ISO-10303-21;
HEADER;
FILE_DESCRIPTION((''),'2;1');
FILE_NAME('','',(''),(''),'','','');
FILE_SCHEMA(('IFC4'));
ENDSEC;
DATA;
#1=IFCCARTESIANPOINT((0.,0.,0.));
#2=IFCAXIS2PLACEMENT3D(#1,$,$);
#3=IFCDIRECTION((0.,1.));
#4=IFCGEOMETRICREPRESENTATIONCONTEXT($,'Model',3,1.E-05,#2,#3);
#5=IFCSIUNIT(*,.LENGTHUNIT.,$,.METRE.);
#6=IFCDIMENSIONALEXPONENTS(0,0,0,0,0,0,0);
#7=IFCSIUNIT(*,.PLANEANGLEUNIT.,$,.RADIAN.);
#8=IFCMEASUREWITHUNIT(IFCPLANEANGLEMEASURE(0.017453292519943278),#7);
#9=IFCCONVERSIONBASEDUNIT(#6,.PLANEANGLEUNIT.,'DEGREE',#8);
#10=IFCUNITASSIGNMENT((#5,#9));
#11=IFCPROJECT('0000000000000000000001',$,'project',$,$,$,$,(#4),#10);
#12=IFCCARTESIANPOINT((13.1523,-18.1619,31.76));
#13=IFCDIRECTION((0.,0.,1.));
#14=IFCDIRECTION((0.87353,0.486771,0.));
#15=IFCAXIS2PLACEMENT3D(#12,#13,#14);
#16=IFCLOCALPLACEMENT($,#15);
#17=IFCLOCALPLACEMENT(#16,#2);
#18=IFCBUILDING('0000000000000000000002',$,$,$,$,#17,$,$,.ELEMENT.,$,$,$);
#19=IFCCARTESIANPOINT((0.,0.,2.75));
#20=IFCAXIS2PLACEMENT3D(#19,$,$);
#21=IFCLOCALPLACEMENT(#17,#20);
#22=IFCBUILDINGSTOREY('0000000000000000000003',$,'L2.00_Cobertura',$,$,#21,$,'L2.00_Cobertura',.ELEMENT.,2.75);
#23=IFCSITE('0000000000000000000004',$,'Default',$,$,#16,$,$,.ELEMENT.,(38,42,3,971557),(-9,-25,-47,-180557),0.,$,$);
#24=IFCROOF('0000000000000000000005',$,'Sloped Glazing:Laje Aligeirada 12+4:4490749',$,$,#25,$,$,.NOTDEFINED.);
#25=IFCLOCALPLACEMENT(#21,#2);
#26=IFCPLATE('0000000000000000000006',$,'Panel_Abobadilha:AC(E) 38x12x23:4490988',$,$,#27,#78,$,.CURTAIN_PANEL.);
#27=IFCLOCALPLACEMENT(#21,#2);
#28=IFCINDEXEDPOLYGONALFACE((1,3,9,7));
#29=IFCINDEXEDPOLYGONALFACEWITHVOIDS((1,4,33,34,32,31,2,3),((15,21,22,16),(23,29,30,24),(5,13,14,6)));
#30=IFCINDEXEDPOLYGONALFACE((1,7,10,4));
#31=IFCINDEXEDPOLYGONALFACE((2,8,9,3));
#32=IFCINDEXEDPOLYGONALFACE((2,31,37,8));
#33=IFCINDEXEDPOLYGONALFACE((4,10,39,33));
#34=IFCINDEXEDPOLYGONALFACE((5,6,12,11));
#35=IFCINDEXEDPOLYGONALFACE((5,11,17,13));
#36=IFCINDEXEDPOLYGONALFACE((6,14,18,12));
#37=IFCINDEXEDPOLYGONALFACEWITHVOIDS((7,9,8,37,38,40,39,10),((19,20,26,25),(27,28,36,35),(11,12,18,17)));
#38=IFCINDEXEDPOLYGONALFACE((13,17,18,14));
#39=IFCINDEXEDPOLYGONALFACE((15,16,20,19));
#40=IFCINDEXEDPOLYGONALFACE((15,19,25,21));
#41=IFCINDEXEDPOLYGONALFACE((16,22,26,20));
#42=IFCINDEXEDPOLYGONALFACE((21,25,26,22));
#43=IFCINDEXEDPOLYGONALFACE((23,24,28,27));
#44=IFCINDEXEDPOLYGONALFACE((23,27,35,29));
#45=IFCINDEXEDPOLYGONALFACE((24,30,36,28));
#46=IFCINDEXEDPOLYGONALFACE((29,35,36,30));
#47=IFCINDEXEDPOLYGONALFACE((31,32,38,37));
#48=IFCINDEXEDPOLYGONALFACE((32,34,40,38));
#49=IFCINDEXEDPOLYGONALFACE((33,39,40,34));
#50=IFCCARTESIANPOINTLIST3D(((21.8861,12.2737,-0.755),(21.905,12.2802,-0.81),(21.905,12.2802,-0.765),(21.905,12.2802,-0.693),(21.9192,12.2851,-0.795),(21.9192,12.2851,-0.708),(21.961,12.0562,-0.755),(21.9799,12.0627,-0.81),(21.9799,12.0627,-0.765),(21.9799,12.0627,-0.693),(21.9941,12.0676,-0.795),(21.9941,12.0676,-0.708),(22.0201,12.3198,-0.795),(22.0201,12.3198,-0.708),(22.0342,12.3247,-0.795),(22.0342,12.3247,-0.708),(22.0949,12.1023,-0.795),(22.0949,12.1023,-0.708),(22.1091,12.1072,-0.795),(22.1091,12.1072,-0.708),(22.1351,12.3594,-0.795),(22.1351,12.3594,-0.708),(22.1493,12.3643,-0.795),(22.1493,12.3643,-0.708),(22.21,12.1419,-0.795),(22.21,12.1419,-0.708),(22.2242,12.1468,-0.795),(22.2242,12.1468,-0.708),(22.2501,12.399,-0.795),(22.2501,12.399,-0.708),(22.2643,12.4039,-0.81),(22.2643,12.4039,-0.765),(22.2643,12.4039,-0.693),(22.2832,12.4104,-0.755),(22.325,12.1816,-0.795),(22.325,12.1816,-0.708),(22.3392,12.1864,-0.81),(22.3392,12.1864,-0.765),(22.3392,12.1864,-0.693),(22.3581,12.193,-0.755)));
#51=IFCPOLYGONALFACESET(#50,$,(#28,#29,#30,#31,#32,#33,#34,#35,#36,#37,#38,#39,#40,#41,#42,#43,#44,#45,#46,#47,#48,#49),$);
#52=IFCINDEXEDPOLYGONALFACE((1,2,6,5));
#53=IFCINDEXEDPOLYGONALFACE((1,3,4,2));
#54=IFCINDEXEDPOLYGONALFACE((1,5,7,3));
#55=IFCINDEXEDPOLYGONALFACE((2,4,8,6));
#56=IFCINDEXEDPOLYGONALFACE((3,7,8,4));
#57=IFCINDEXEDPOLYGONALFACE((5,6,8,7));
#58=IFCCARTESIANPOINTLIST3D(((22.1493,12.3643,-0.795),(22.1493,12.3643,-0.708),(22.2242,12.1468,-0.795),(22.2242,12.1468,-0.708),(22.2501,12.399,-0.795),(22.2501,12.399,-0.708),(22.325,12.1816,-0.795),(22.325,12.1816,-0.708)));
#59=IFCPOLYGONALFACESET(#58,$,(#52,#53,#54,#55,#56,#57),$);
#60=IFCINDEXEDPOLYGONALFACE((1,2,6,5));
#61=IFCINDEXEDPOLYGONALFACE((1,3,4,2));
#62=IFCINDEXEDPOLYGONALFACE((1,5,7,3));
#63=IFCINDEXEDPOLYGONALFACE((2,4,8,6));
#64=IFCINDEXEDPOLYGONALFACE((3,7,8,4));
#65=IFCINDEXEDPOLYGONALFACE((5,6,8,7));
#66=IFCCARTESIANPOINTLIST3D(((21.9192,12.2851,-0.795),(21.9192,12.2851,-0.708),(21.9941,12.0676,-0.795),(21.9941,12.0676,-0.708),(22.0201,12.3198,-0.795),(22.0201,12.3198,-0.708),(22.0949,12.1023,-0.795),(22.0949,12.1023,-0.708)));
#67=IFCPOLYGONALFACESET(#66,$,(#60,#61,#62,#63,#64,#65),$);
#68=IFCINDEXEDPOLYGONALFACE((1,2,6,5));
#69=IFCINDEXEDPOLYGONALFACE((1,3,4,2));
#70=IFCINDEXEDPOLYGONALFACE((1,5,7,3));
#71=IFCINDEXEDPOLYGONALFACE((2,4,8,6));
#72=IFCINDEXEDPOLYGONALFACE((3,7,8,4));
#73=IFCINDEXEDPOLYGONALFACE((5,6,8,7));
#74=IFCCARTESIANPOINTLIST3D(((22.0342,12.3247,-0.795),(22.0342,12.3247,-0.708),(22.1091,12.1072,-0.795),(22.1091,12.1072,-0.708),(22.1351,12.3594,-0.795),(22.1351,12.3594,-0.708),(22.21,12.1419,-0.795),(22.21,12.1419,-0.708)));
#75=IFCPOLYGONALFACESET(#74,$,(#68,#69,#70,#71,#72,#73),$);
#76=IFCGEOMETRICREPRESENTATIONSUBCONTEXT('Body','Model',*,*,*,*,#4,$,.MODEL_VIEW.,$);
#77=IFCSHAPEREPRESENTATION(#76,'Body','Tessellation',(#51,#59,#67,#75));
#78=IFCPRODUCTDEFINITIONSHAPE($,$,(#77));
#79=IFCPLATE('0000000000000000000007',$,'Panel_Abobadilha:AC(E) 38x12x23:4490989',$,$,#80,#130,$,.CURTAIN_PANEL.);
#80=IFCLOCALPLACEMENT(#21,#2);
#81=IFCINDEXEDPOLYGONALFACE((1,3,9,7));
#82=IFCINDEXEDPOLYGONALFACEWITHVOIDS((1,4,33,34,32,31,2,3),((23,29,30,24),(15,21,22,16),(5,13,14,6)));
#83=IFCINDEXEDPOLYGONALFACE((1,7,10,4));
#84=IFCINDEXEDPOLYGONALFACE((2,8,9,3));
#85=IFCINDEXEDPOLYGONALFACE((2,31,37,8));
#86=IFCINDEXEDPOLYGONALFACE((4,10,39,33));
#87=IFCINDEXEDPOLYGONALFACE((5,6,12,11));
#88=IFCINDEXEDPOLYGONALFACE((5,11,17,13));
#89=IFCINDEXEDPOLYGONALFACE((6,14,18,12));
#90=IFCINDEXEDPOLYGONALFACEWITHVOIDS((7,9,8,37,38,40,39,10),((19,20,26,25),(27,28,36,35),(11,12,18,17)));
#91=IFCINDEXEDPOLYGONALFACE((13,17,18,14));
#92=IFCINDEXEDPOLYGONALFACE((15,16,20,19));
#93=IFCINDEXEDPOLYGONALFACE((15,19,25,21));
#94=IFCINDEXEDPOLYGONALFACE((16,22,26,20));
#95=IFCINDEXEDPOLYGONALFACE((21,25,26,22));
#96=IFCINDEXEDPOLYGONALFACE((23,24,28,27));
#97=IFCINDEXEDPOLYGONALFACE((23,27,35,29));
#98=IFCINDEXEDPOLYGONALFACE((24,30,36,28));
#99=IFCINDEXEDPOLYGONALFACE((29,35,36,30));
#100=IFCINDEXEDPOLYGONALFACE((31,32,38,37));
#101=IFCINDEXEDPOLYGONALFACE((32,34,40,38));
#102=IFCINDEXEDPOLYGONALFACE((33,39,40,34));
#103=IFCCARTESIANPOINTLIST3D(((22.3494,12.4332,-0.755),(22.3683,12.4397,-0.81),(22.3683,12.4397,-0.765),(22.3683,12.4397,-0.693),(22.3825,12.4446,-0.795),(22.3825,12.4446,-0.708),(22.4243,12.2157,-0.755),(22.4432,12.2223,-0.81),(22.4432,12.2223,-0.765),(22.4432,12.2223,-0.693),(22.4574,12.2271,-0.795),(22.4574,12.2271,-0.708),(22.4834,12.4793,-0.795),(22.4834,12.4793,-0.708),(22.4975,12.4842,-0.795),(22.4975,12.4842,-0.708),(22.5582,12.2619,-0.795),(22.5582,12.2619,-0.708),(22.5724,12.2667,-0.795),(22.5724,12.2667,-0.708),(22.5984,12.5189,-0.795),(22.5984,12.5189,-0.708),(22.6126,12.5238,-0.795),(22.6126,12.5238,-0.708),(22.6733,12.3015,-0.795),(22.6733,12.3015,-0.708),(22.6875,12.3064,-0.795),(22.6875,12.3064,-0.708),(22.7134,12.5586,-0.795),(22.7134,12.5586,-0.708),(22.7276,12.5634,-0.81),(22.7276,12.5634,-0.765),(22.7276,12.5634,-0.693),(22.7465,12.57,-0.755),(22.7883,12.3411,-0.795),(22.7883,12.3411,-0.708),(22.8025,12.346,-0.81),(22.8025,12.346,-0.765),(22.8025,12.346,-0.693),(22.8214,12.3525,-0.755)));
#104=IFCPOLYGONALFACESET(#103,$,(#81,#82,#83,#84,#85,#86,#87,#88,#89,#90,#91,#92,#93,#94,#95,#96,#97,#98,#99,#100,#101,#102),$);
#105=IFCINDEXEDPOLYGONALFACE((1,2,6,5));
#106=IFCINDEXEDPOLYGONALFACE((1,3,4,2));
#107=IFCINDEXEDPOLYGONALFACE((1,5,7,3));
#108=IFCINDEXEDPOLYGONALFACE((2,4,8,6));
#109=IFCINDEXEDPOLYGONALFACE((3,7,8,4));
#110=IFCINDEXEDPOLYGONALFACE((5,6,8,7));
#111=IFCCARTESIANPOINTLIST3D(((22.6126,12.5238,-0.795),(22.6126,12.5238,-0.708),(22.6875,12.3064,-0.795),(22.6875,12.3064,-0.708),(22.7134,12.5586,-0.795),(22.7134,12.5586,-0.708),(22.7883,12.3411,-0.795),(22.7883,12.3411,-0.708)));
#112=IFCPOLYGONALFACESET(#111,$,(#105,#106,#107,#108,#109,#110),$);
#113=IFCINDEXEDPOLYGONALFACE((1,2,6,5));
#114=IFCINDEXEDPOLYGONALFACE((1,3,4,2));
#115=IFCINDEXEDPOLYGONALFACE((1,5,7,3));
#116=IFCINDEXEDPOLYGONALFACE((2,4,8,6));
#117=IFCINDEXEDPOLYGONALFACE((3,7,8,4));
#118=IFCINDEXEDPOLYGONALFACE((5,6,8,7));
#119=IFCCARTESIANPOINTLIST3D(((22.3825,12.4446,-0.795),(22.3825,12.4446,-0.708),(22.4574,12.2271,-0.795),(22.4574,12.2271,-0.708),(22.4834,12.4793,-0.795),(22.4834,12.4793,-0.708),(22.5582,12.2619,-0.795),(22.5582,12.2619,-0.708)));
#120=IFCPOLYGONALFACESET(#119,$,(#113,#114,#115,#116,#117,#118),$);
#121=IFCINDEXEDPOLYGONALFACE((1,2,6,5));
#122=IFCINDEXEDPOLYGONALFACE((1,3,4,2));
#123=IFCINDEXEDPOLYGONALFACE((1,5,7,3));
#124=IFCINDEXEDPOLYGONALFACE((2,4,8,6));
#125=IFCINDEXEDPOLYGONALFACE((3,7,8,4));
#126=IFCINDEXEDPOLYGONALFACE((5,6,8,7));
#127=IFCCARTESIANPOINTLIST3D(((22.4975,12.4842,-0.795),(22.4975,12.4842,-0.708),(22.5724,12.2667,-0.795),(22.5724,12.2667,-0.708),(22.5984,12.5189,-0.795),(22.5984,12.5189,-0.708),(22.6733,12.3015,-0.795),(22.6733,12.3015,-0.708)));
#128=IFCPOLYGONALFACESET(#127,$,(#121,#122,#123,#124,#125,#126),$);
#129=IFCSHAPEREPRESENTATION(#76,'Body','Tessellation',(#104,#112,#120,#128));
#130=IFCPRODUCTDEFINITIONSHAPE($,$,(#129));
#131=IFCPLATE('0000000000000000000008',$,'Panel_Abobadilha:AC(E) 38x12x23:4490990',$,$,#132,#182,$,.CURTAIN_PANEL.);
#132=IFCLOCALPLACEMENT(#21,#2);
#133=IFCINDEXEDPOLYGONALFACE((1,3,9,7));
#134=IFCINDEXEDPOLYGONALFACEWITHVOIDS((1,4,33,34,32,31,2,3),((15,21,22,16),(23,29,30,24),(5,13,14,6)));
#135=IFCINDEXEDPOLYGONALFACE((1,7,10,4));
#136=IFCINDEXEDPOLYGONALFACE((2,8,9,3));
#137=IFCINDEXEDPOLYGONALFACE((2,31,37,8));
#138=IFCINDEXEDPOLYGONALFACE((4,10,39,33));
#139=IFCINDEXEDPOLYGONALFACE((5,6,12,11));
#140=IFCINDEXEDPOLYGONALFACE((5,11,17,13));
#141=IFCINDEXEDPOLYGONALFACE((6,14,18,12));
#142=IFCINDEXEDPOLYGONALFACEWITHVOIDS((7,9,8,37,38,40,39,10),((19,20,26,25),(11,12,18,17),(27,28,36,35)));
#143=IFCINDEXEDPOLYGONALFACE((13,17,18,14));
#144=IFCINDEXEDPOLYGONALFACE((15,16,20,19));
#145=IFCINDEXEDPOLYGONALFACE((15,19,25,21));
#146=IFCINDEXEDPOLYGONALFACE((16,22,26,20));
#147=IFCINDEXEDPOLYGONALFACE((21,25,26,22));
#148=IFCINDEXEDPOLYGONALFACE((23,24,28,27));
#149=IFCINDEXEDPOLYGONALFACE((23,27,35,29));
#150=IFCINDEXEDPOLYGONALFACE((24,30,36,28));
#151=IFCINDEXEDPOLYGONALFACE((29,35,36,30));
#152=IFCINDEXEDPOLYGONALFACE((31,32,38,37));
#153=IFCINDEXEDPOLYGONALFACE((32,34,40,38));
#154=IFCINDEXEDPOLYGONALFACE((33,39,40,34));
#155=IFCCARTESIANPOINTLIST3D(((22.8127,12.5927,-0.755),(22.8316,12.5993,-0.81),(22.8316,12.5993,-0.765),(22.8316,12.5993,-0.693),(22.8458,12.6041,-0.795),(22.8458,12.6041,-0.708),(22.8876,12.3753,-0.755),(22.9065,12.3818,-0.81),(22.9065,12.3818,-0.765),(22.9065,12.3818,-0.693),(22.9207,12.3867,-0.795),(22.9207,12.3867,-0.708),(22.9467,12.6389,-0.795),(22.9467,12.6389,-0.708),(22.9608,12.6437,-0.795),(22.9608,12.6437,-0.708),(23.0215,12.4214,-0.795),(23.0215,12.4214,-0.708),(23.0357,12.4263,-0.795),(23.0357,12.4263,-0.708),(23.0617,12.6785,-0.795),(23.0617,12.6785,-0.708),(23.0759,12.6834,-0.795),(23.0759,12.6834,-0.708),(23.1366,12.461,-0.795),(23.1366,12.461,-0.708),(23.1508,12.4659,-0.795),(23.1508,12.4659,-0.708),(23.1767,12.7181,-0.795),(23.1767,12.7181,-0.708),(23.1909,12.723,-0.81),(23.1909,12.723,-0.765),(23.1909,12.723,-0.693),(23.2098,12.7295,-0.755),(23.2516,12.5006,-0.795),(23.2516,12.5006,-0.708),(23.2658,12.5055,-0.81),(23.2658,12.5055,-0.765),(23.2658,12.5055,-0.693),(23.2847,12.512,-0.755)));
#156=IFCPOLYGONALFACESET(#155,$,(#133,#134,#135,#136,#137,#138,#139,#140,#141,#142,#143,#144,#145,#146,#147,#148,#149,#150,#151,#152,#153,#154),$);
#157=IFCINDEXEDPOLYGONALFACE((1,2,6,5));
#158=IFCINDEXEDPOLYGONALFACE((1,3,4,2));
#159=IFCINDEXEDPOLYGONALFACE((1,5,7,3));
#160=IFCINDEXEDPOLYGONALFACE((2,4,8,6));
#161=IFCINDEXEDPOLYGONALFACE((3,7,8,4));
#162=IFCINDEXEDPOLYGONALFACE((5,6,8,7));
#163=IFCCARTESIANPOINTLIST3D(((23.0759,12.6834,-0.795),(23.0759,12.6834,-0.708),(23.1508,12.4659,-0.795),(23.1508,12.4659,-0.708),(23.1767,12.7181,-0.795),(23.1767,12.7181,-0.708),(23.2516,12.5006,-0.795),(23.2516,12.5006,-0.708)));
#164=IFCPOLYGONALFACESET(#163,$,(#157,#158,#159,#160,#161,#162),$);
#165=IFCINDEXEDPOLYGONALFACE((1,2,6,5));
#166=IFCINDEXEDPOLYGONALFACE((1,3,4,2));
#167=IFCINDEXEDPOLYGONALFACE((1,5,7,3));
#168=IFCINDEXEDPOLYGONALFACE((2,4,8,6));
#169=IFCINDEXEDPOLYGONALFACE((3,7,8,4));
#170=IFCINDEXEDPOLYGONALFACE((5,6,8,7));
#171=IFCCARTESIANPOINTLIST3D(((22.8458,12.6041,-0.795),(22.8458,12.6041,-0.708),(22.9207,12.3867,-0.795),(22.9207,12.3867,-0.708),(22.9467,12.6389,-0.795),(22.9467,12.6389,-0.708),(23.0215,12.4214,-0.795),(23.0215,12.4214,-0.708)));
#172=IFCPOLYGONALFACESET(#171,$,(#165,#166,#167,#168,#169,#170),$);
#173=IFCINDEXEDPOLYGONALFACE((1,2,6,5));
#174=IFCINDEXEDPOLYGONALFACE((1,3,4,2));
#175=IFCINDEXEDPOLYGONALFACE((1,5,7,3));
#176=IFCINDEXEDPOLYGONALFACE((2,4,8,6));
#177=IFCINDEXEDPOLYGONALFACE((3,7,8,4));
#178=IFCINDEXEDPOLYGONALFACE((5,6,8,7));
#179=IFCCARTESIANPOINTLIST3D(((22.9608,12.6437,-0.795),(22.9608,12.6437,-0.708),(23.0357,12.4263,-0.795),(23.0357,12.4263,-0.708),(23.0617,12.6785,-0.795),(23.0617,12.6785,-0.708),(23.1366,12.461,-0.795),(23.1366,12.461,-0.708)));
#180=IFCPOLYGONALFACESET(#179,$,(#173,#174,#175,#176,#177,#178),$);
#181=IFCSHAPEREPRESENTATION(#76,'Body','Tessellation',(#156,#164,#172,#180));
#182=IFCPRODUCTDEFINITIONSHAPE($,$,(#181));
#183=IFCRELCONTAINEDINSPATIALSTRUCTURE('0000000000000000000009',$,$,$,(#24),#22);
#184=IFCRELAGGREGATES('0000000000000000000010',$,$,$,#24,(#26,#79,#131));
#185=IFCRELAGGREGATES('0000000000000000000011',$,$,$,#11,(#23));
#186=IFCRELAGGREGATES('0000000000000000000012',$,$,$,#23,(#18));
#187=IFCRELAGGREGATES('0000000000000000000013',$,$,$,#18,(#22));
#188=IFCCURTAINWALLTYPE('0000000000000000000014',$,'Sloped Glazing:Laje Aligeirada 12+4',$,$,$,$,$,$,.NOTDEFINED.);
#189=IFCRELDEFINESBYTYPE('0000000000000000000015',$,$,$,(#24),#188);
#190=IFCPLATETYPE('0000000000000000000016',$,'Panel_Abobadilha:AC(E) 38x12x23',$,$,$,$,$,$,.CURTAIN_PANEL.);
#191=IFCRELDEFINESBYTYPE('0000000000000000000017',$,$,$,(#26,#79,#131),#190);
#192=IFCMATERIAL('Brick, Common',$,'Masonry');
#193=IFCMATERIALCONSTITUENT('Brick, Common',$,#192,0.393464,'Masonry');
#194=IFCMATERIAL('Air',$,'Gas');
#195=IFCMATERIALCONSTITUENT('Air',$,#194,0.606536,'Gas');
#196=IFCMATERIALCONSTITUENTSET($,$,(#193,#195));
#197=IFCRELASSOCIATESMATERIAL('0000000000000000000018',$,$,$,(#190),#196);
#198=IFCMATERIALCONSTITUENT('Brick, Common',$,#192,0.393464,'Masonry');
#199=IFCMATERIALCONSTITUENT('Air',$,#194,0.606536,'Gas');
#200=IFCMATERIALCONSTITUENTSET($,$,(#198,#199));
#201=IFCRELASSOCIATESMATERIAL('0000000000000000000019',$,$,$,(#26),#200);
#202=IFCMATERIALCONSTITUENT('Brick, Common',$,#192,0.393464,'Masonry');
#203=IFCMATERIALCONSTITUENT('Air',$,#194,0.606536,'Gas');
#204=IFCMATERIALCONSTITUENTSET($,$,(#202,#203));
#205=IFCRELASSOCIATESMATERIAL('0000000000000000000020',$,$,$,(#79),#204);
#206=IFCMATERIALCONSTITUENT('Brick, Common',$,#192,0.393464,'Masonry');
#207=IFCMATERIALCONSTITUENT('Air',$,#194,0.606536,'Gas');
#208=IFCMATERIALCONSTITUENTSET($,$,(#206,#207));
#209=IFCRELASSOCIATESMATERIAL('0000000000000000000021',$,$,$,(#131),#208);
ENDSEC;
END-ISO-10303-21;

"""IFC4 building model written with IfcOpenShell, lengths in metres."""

from ifc_helpers import new_model, entity, si_unit, converted_unit, direction, frame, origin, place, context, subcontext, project, spatial, indexed_curve, outline, extrude, source, transform, mapped, material, constituent, constituent_set, type_object, type_shapes, element, aggregate, save


model = new_model("IFC4")

# Units and contexts
model_context = context("Model", 3, precision=1e-05, world=origin(), true_north=direction((0.0, 1.0)))
body_context = subcontext(model_context, "Body", "Model", "MODEL_VIEW")
ifc_project = project(units=[si_unit("LENGTHUNIT", "METRE"), converted_unit("PLANEANGLEUNIT", "DEGREE", entity("IfcPlaneAngleMeasure", 0.017453292519943278), si_unit("PLANEANGLEUNIT", "RADIAN"), dimensions=[0, 0, 0, 0, 0, 0, 0])], contexts=[model_context])

# Site, building, storey
site_placement = place(None, frame((13.1523, -18.1619, 31.76), z_axis=(0.0, 0.0, 1.0), x_axis=(0.87353, 0.486771, 0.0)))
site = spatial("IfcSite", under=ifc_project, at=site_placement, Name="Default", CompositionType="ELEMENT", RefLatitude=(38, 42, 3, 971557), RefLongitude=(-9, -25, -47, -180557), RefElevation=0.0)
building_placement = place(site_placement, origin())
building = spatial("IfcBuilding", under=site, at=building_placement, CompositionType="ELEMENT")
storey_placement = place(building_placement, frame((0.0, 0.0, 2.75)))
storey = spatial("IfcBuildingStorey", under=building, at=storey_placement, Name="L2.00_Cobertura", LongName="L2.00_Cobertura", CompositionType="ELEMENT", Elevation=2.75)

# Roof, plates
curtain_wall_type = type_object("IfcCurtainWallType", Name="Sloped Glazing:Laje Aligeirada 12+4", PredefinedType="NOTDEFINED")
roof_placement = place(storey_placement, frame((0.0, 0.0, -2.75)))
roof = element("IfcRoof", 1, at=roof_placement, inside=storey, type_object=curtain_wall_type, Name="Sloped Glazing:Laje Aligeirada 12+4:4490749", PredefinedType="NOTDEFINED")
ifc_material_1 = material(Name="Brick, Common", Category="Masonry")
ifc_material_2 = material(Name="Air", Category="Gas")
ifc_constituent_1 = constituent(ifc_material_1, Name="Brick, Common", Category="Masonry", fraction=0.393464)
ifc_constituent_2 = constituent(ifc_material_2, Name="Air", Category="Gas", fraction=0.606536)
ifc_constituent_set_1 = constituent_set(constituents=[ifc_constituent_1, ifc_constituent_2])
plate_type = type_object("IfcPlateType", Name="Panel_Abobadilha:AC(E) 38x12x23", PredefinedType="CURTAIN_PANEL", material=ifc_constituent_set_1)
shared_shape_1 = source(origin(), body_context, "Body", "SweptSolid", [
    extrude(outline(indexed_curve([(-0.19, -0.0543), (0.19, -0.0543), (0.19, -0.0093), (0.21, 0.0007), (0.19, 0.0628), (-0.19, 0.0628), (-0.21, 0.0007), (-0.19, -0.0093), (-0.19, -0.0543)], self_intersect=False), holes=[indexed_curve([(-0.0683, 0.0477), (-0.0683, -0.0393), (-0.175, -0.0393), (-0.175, 0.0477), (-0.0683, 0.0477)], self_intersect=False), indexed_curve([(0.0533, 0.0477), (0.0533, -0.0393), (-0.0533, -0.0393), (-0.0533, 0.0477), (0.0533, 0.0477)], self_intersect=False), indexed_curve([(0.175, 0.0477), (0.175, -0.0393), (0.0683, -0.0393), (0.0683, 0.0477), (0.175, 0.0477)], self_intersect=False)]), frame((0.0, 0.0543, 0.0)), (0.0, 0.0, 1.0), 0.23),
    extrude(outline(indexed_curve([(-0.0533, -0.0435), (0.0533, -0.0435), (0.0533, 0.0435), (-0.0533, 0.0435), (-0.0533, -0.0435)], self_intersect=False)), frame((0.1217, 0.0585, 0.0), z_axis=(0.0, 0.0, 1.0), x_axis=(-1.0, 0.0, 0.0)), (0.0, 0.0, 1.0), 0.23),
    extrude(outline(indexed_curve([(-0.0533, -0.0435), (0.0533, -0.0435), (0.0533, 0.0435), (-0.0533, 0.0435), (-0.0533, -0.0435)], self_intersect=False)), frame((-0.1217, 0.0585, 0.0), z_axis=(0.0, 0.0, 1.0), x_axis=(-1.0, 0.0, 0.0)), (0.0, 0.0, 1.0), 0.23),
    extrude(outline(indexed_curve([(-0.0533, -0.0435), (0.0533, -0.0435), (0.0533, 0.0435), (-0.0533, 0.0435), (-0.0533, -0.0435)], self_intersect=False)), frame((0.0, 0.0585, 0.0), z_axis=(0.0, 0.0, 1.0), x_axis=(-1.0, 0.0, 0.0)), (0.0, 0.0, 1.0), 0.23),
])
type_shapes(plate_type, [shared_shape_1])
ifc_constituent_3 = constituent(ifc_material_1, Name="Brick, Common", Category="Masonry", fraction=0.393464)
ifc_constituent_4 = constituent(ifc_material_2, Name="Air", Category="Gas", fraction=0.606536)
ifc_constituent_set_2 = constituent_set(constituents=[ifc_constituent_3, ifc_constituent_4])
plate_1_placement = place(roof_placement, frame((22.0847, 12.3421, 1.94), z_axis=(0.325568, -0.945519, 0.0), x_axis=(0.945519, 0.325568, 0.0)))
plate_1 = element("IfcPlate", 2, at=plate_1_placement, type_object=plate_type, material=ifc_constituent_set_2, Name="Panel_Abobadilha:AC(E) 38x12x23:4490988", PredefinedType="CURTAIN_PANEL", context=body_context, shape_type="MappedRepresentation", body=[
    mapped(shared_shape_1, transform((0.0, 0.0, 0.0), scale=1.0)),
])
ifc_constituent_5 = constituent(ifc_material_1, Name="Brick, Common", Category="Masonry", fraction=0.393464)
ifc_constituent_6 = constituent(ifc_material_2, Name="Air", Category="Gas", fraction=0.606536)
ifc_constituent_set_3 = constituent_set(constituents=[ifc_constituent_5, ifc_constituent_6])
plate_2_placement = place(roof_placement, frame((22.548, 12.5016, 1.94), z_axis=(0.325568, -0.945519, 0.0), x_axis=(0.945519, 0.325568, 0.0)))
plate_2 = element("IfcPlate", 3, at=plate_2_placement, type_object=plate_type, material=ifc_constituent_set_3, Name="Panel_Abobadilha:AC(E) 38x12x23:4490989", PredefinedType="CURTAIN_PANEL", context=body_context, shape_type="MappedRepresentation", body=[
    mapped(shared_shape_1, transform((0.0, 0.0, 0.0), scale=1.0)),
])
ifc_constituent_7 = constituent(ifc_material_1, Name="Brick, Common", Category="Masonry", fraction=0.393464)
ifc_constituent_8 = constituent(ifc_material_2, Name="Air", Category="Gas", fraction=0.606536)
ifc_constituent_set_4 = constituent_set(constituents=[ifc_constituent_7, ifc_constituent_8])
plate_3_placement = place(roof_placement, frame((23.0113, 12.6611, 1.94), z_axis=(0.325568, -0.945519, 0.0), x_axis=(0.945519, 0.325568, 0.0)))
plate_3 = element("IfcPlate", 4, at=plate_3_placement, type_object=plate_type, material=ifc_constituent_set_4, Name="Panel_Abobadilha:AC(E) 38x12x23:4490990", PredefinedType="CURTAIN_PANEL", context=body_context, shape_type="MappedRepresentation", body=[
    mapped(shared_shape_1, transform((0.0, 0.0, 0.0), scale=1.0)),
])
aggregate(roof, [plate_1, plate_2, plate_3])

save(model, "model.ifc")
